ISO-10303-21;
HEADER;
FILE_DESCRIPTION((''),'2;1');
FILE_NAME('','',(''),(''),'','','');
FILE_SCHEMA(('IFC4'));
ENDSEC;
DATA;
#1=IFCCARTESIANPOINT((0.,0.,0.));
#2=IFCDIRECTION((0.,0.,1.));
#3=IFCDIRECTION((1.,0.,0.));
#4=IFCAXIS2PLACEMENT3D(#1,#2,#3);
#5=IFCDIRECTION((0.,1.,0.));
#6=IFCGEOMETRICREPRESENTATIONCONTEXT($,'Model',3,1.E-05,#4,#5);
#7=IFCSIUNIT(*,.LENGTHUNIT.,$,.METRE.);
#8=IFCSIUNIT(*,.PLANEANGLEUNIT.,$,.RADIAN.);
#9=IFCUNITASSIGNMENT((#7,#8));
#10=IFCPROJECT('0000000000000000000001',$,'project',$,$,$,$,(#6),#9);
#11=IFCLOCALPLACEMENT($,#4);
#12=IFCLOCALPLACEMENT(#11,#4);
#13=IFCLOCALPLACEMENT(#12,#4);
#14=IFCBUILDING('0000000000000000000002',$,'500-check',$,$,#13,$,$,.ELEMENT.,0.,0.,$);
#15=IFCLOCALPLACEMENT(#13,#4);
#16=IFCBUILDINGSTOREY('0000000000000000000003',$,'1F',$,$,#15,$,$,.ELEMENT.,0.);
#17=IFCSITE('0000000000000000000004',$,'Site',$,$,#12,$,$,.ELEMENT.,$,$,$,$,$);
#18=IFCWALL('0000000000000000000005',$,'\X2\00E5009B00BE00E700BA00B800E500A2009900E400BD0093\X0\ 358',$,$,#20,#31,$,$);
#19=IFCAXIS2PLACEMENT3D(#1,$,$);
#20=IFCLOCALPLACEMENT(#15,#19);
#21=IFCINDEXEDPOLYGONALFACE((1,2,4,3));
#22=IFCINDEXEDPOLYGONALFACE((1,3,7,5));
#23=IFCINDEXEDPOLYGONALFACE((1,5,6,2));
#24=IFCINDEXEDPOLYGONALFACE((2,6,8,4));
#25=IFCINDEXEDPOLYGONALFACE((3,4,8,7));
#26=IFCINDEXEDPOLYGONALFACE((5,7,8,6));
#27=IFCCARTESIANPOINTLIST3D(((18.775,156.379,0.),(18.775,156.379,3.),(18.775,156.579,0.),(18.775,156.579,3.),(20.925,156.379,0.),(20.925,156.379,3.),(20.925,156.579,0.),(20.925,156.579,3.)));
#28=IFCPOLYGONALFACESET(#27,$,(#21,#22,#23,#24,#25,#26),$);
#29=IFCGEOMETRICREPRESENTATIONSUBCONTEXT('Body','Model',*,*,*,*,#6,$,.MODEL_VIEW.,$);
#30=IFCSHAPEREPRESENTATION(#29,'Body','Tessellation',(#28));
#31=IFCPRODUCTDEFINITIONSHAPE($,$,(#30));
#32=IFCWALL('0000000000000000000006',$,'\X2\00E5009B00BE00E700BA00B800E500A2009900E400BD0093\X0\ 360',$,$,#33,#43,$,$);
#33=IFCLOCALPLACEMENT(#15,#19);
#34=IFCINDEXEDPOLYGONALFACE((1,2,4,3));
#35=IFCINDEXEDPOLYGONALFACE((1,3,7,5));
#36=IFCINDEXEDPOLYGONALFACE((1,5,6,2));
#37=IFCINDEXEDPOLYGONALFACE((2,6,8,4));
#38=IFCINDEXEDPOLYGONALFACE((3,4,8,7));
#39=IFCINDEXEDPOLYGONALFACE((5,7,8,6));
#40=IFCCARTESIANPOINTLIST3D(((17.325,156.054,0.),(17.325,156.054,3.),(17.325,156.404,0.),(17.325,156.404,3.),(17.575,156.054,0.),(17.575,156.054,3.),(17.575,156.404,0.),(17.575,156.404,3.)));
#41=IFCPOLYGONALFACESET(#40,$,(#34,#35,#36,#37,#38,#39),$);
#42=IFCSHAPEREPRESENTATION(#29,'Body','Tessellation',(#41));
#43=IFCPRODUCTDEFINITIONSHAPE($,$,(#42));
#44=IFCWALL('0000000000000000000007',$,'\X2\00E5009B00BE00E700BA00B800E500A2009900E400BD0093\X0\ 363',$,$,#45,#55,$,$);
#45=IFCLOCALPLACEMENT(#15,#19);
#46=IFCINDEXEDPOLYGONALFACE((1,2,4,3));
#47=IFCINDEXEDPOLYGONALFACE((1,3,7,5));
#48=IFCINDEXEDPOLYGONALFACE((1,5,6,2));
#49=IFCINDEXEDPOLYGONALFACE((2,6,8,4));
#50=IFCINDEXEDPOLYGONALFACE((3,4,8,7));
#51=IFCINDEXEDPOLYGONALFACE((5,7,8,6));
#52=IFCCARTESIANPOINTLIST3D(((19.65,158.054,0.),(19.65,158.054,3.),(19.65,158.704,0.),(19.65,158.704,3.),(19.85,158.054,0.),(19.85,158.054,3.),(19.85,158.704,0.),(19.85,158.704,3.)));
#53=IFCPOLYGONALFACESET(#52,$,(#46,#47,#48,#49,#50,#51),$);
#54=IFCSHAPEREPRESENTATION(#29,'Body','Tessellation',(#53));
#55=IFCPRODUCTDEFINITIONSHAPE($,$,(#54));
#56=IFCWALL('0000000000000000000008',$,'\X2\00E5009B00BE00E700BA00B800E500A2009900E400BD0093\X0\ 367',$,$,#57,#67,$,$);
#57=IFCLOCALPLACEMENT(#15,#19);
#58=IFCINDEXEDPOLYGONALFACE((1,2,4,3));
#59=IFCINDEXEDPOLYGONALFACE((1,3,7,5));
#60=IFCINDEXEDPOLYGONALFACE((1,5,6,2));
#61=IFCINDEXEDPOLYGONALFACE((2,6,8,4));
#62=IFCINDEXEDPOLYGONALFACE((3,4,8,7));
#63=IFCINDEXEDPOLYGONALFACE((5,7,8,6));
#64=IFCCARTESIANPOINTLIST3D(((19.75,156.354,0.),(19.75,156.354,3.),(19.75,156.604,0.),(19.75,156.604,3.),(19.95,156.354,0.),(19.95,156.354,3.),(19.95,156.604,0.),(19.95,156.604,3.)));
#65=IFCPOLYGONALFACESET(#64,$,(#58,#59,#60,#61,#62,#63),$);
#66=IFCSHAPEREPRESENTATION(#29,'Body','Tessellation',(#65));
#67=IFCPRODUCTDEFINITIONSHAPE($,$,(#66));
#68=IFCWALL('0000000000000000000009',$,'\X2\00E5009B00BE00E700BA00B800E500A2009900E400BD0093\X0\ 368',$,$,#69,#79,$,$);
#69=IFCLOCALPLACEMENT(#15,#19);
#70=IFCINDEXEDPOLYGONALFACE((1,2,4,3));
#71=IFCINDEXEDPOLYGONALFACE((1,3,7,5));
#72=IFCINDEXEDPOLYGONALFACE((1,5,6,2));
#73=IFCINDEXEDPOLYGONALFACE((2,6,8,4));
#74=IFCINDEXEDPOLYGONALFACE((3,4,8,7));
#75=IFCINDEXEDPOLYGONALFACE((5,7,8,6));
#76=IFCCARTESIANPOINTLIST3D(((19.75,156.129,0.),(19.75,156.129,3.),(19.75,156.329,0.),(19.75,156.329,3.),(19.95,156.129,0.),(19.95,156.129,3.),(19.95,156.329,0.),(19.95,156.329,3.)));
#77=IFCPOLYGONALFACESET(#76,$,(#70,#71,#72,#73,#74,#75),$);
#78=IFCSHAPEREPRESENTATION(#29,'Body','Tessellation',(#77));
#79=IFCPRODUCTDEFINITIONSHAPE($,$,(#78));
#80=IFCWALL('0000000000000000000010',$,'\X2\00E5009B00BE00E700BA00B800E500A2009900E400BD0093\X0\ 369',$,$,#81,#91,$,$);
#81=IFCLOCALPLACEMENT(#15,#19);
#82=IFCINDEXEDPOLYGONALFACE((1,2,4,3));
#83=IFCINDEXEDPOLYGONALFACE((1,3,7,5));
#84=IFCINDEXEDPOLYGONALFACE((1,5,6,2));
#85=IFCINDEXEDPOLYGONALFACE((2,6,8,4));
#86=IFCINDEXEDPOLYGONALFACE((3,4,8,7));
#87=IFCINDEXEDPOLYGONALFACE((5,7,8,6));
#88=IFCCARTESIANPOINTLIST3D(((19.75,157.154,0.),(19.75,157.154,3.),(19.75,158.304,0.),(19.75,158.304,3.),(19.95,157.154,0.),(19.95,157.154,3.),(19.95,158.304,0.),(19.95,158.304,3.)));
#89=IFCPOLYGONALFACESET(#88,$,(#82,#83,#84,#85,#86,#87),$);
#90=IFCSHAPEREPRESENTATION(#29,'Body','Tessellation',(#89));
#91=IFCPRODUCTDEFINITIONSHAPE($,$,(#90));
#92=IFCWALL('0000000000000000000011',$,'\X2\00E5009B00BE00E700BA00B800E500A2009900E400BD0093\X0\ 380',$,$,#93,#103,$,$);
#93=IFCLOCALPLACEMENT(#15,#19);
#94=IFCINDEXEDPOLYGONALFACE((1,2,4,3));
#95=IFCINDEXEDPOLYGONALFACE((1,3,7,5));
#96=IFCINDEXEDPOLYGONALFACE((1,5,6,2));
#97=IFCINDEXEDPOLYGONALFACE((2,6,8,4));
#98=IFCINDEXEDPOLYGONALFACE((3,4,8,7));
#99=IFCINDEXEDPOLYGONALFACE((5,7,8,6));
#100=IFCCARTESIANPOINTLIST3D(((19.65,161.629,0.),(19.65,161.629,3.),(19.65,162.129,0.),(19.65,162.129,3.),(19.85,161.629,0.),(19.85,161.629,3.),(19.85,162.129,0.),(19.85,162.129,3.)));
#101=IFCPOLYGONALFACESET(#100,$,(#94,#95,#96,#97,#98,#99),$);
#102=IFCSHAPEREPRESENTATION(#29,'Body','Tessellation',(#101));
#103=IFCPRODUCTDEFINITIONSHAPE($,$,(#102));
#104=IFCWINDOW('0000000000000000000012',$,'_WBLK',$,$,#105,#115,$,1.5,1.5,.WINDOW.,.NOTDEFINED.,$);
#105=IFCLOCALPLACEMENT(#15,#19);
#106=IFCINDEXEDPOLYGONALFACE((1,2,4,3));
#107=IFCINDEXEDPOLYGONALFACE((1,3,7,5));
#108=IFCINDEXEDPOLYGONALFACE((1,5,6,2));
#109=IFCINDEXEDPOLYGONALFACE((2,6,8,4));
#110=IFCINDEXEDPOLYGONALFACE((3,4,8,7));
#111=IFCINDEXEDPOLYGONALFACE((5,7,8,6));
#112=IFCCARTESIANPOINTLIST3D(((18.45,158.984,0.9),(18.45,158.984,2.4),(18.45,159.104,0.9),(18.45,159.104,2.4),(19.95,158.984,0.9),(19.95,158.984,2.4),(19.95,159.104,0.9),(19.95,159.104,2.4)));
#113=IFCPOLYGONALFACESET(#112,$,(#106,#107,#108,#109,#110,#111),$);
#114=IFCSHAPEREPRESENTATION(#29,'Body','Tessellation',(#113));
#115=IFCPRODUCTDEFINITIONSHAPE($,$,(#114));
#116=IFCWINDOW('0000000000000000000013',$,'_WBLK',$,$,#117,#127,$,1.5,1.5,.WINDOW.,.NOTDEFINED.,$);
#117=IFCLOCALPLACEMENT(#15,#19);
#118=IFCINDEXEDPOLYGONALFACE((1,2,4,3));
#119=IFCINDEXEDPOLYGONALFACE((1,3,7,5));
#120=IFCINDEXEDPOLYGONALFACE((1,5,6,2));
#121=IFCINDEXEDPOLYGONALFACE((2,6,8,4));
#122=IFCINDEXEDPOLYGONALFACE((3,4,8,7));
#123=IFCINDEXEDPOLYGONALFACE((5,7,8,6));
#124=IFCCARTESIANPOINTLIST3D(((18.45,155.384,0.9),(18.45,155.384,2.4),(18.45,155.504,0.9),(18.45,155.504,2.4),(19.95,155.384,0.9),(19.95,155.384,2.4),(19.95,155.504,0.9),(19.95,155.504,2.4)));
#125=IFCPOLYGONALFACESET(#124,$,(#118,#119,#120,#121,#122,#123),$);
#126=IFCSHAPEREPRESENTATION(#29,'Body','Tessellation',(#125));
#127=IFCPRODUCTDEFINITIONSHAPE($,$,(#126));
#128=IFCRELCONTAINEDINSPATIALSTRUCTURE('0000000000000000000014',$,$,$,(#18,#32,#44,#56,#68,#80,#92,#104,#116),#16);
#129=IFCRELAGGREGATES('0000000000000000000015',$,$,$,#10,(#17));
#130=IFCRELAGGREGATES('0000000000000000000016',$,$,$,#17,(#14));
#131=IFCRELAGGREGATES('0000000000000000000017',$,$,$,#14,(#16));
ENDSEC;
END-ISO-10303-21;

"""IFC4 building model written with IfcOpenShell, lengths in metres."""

from ifc_helpers import new_model, si_unit, direction, frame, frame_2d, origin_with_axes, place, context, subcontext, project, spatial, rectangle, extrude, element, save


model = new_model("IFC4")

# Units and contexts
model_context = context("Model", 3, precision=1e-05, world=origin_with_axes(), true_north=direction((0.0, 1.0, 0.0)))
body_context = subcontext(model_context, "Body", "Model", "MODEL_VIEW")
ifc_project = project(units=[si_unit("LENGTHUNIT", "METRE"), si_unit("PLANEANGLEUNIT", "RADIAN")], contexts=[model_context])

# Site, building, storey
placement = place(None, origin_with_axes())
site_placement = place(placement, origin_with_axes())
site = spatial("IfcSite", under=ifc_project, at=site_placement, Name="Site", CompositionType="ELEMENT")
building_placement = place(site_placement, origin_with_axes())
building = spatial("IfcBuilding", under=site, at=building_placement, Name="500-check", CompositionType="ELEMENT", ElevationOfRefHeight=0.0, ElevationOfTerrain=0.0)
storey_placement = place(building_placement, origin_with_axes())
storey = spatial("IfcBuildingStorey", under=building, at=storey_placement, Name="1F", CompositionType="ELEMENT", Elevation=0.0)

# Walls
wall_1_placement = place(storey_placement, frame((19.85, 156.479, 0.0), z_axis=(0.0, 0.0, 1.0), x_axis=(-1.0, 0.0, 0.0)))
element("IfcWall", 1, at=wall_1_placement, inside=storey, Name="å\u009b¾çº¸å¢\u0099ä½\u0093 358", context=body_context, shape_type="SweptSolid", body=[
    extrude(rectangle(XDim=2.15, YDim=0.2, at=frame_2d((0.0, 0.0), x_axis=(1.0, 0.0, 0.0))), frame((0.0, 0.0, 0.0), z_axis=(0.0, 0.0, 1.0)), (0.0, 0.0, 1.0), 3.0),
])
wall_2_placement = place(storey_placement, frame((17.45, 156.229, 0.0), z_axis=(0.0, 0.0, 1.0), x_axis=(1.0, 0.0, 0.0)))
element("IfcWall", 2, at=wall_2_placement, inside=storey, Name="å\u009b¾çº¸å¢\u0099ä½\u0093 360", context=body_context, shape_type="SweptSolid", body=[
    extrude(rectangle(XDim=0.25, YDim=0.35, at=frame_2d((0.0, 0.0), x_axis=(1.0, 0.0, 0.0))), frame((0.0, 0.0, 0.0), z_axis=(0.0, 0.0, 1.0)), (0.0, 0.0, 1.0), 3.0),
])
wall_3_placement = place(storey_placement, frame((19.75, 158.379, 0.0), z_axis=(0.0, 0.0, 1.0), x_axis=(0.0, -1.0, 0.0)))
element("IfcWall", 3, at=wall_3_placement, inside=storey, Name="å\u009b¾çº¸å¢\u0099ä½\u0093 363", context=body_context, shape_type="SweptSolid", body=[
    extrude(rectangle(XDim=0.65, YDim=0.2, at=frame_2d((0.0, 0.0), x_axis=(1.0, 0.0, 0.0))), frame((0.0, 0.0, 0.0), z_axis=(0.0, 0.0, 1.0)), (0.0, 0.0, 1.0), 3.0),
])
wall_4_placement = place(storey_placement, frame((19.85, 156.479, 0.0), z_axis=(0.0, 0.0, 1.0), x_axis=(0.0, -1.0, 0.0)))
element("IfcWall", 4, at=wall_4_placement, inside=storey, Name="å\u009b¾çº¸å¢\u0099ä½\u0093 367", context=body_context, shape_type="SweptSolid", body=[
    extrude(rectangle(XDim=0.25, YDim=0.2, at=frame_2d((0.0, 0.0), x_axis=(1.0, 0.0, 0.0))), frame((0.0, 0.0, 0.0), z_axis=(0.0, 0.0, 1.0)), (0.0, 0.0, 1.0), 3.0),
])
wall_5_placement = place(storey_placement, frame((19.85, 156.229, 0.0), z_axis=(0.0, 0.0, 1.0), x_axis=(1.0, 0.0, 0.0)))
element("IfcWall", 5, at=wall_5_placement, inside=storey, Name="å\u009b¾çº¸å¢\u0099ä½\u0093 368", context=body_context, shape_type="SweptSolid", body=[
    extrude(rectangle(XDim=0.2, YDim=0.2, at=frame_2d((0.0, 0.0), x_axis=(1.0, 0.0, 0.0))), frame((0.0, 0.0, 0.0), z_axis=(0.0, 0.0, 1.0)), (0.0, 0.0, 1.0), 3.0),
])
wall_6_placement = place(storey_placement, frame((19.85, 157.729, 0.0), z_axis=(0.0, 0.0, 1.0), x_axis=(0.0, -1.0, 0.0)))
element("IfcWall", 6, at=wall_6_placement, inside=storey, Name="å\u009b¾çº¸å¢\u0099ä½\u0093 369", context=body_context, shape_type="SweptSolid", body=[
    extrude(rectangle(XDim=1.15, YDim=0.2, at=frame_2d((0.0, 0.0), x_axis=(1.0, 0.0, 0.0))), frame((0.0, 0.0, 0.0), z_axis=(0.0, 0.0, 1.0)), (0.0, 0.0, 1.0), 3.0),
])
wall_7_placement = place(storey_placement, frame((19.75, 161.879, 0.0), z_axis=(0.0, 0.0, 1.0), x_axis=(0.0, -1.0, 0.0)))
element("IfcWall", 7, at=wall_7_placement, inside=storey, Name="å\u009b¾çº¸å¢\u0099ä½\u0093 380", context=body_context, shape_type="SweptSolid", body=[
    extrude(rectangle(XDim=0.5, YDim=0.2, at=frame_2d((0.0, 0.0), x_axis=(1.0, 0.0, 0.0))), frame((0.0, 0.0, 0.0), z_axis=(0.0, 0.0, 1.0)), (0.0, 0.0, 1.0), 3.0),
])

# Windows
for number, where, z_axis, x_axis, name in (
    (8, (19.2, 159.044, 0.9), (0.0, 0.0, 1.0), (1.0, 0.0, 0.0), "_WBLK"),
    (9, (19.2, 155.444, 0.9), (0.0, 0.0, 1.0), (1.0, 0.0, 0.0), "_WBLK"),
):
    element("IfcWindow", number, at=place(storey_placement, frame(where, z_axis=z_axis, x_axis=x_axis)), inside=storey, Name=name, OverallHeight=1.5, OverallWidth=1.5, PartitioningType="NOTDEFINED", PredefinedType="WINDOW", context=body_context, shape_type="SweptSolid", body=[
        extrude(rectangle(XDim=1.5, YDim=0.12, at=frame_2d((0.0, 0.0), x_axis=(1.0, 0.0, 0.0))), frame((0.0, 0.0, 0.0), z_axis=(0.0, 0.0, 1.0)), (0.0, 0.0, 1.0), 1.5),
    ])

save(model, "model.ifc")
